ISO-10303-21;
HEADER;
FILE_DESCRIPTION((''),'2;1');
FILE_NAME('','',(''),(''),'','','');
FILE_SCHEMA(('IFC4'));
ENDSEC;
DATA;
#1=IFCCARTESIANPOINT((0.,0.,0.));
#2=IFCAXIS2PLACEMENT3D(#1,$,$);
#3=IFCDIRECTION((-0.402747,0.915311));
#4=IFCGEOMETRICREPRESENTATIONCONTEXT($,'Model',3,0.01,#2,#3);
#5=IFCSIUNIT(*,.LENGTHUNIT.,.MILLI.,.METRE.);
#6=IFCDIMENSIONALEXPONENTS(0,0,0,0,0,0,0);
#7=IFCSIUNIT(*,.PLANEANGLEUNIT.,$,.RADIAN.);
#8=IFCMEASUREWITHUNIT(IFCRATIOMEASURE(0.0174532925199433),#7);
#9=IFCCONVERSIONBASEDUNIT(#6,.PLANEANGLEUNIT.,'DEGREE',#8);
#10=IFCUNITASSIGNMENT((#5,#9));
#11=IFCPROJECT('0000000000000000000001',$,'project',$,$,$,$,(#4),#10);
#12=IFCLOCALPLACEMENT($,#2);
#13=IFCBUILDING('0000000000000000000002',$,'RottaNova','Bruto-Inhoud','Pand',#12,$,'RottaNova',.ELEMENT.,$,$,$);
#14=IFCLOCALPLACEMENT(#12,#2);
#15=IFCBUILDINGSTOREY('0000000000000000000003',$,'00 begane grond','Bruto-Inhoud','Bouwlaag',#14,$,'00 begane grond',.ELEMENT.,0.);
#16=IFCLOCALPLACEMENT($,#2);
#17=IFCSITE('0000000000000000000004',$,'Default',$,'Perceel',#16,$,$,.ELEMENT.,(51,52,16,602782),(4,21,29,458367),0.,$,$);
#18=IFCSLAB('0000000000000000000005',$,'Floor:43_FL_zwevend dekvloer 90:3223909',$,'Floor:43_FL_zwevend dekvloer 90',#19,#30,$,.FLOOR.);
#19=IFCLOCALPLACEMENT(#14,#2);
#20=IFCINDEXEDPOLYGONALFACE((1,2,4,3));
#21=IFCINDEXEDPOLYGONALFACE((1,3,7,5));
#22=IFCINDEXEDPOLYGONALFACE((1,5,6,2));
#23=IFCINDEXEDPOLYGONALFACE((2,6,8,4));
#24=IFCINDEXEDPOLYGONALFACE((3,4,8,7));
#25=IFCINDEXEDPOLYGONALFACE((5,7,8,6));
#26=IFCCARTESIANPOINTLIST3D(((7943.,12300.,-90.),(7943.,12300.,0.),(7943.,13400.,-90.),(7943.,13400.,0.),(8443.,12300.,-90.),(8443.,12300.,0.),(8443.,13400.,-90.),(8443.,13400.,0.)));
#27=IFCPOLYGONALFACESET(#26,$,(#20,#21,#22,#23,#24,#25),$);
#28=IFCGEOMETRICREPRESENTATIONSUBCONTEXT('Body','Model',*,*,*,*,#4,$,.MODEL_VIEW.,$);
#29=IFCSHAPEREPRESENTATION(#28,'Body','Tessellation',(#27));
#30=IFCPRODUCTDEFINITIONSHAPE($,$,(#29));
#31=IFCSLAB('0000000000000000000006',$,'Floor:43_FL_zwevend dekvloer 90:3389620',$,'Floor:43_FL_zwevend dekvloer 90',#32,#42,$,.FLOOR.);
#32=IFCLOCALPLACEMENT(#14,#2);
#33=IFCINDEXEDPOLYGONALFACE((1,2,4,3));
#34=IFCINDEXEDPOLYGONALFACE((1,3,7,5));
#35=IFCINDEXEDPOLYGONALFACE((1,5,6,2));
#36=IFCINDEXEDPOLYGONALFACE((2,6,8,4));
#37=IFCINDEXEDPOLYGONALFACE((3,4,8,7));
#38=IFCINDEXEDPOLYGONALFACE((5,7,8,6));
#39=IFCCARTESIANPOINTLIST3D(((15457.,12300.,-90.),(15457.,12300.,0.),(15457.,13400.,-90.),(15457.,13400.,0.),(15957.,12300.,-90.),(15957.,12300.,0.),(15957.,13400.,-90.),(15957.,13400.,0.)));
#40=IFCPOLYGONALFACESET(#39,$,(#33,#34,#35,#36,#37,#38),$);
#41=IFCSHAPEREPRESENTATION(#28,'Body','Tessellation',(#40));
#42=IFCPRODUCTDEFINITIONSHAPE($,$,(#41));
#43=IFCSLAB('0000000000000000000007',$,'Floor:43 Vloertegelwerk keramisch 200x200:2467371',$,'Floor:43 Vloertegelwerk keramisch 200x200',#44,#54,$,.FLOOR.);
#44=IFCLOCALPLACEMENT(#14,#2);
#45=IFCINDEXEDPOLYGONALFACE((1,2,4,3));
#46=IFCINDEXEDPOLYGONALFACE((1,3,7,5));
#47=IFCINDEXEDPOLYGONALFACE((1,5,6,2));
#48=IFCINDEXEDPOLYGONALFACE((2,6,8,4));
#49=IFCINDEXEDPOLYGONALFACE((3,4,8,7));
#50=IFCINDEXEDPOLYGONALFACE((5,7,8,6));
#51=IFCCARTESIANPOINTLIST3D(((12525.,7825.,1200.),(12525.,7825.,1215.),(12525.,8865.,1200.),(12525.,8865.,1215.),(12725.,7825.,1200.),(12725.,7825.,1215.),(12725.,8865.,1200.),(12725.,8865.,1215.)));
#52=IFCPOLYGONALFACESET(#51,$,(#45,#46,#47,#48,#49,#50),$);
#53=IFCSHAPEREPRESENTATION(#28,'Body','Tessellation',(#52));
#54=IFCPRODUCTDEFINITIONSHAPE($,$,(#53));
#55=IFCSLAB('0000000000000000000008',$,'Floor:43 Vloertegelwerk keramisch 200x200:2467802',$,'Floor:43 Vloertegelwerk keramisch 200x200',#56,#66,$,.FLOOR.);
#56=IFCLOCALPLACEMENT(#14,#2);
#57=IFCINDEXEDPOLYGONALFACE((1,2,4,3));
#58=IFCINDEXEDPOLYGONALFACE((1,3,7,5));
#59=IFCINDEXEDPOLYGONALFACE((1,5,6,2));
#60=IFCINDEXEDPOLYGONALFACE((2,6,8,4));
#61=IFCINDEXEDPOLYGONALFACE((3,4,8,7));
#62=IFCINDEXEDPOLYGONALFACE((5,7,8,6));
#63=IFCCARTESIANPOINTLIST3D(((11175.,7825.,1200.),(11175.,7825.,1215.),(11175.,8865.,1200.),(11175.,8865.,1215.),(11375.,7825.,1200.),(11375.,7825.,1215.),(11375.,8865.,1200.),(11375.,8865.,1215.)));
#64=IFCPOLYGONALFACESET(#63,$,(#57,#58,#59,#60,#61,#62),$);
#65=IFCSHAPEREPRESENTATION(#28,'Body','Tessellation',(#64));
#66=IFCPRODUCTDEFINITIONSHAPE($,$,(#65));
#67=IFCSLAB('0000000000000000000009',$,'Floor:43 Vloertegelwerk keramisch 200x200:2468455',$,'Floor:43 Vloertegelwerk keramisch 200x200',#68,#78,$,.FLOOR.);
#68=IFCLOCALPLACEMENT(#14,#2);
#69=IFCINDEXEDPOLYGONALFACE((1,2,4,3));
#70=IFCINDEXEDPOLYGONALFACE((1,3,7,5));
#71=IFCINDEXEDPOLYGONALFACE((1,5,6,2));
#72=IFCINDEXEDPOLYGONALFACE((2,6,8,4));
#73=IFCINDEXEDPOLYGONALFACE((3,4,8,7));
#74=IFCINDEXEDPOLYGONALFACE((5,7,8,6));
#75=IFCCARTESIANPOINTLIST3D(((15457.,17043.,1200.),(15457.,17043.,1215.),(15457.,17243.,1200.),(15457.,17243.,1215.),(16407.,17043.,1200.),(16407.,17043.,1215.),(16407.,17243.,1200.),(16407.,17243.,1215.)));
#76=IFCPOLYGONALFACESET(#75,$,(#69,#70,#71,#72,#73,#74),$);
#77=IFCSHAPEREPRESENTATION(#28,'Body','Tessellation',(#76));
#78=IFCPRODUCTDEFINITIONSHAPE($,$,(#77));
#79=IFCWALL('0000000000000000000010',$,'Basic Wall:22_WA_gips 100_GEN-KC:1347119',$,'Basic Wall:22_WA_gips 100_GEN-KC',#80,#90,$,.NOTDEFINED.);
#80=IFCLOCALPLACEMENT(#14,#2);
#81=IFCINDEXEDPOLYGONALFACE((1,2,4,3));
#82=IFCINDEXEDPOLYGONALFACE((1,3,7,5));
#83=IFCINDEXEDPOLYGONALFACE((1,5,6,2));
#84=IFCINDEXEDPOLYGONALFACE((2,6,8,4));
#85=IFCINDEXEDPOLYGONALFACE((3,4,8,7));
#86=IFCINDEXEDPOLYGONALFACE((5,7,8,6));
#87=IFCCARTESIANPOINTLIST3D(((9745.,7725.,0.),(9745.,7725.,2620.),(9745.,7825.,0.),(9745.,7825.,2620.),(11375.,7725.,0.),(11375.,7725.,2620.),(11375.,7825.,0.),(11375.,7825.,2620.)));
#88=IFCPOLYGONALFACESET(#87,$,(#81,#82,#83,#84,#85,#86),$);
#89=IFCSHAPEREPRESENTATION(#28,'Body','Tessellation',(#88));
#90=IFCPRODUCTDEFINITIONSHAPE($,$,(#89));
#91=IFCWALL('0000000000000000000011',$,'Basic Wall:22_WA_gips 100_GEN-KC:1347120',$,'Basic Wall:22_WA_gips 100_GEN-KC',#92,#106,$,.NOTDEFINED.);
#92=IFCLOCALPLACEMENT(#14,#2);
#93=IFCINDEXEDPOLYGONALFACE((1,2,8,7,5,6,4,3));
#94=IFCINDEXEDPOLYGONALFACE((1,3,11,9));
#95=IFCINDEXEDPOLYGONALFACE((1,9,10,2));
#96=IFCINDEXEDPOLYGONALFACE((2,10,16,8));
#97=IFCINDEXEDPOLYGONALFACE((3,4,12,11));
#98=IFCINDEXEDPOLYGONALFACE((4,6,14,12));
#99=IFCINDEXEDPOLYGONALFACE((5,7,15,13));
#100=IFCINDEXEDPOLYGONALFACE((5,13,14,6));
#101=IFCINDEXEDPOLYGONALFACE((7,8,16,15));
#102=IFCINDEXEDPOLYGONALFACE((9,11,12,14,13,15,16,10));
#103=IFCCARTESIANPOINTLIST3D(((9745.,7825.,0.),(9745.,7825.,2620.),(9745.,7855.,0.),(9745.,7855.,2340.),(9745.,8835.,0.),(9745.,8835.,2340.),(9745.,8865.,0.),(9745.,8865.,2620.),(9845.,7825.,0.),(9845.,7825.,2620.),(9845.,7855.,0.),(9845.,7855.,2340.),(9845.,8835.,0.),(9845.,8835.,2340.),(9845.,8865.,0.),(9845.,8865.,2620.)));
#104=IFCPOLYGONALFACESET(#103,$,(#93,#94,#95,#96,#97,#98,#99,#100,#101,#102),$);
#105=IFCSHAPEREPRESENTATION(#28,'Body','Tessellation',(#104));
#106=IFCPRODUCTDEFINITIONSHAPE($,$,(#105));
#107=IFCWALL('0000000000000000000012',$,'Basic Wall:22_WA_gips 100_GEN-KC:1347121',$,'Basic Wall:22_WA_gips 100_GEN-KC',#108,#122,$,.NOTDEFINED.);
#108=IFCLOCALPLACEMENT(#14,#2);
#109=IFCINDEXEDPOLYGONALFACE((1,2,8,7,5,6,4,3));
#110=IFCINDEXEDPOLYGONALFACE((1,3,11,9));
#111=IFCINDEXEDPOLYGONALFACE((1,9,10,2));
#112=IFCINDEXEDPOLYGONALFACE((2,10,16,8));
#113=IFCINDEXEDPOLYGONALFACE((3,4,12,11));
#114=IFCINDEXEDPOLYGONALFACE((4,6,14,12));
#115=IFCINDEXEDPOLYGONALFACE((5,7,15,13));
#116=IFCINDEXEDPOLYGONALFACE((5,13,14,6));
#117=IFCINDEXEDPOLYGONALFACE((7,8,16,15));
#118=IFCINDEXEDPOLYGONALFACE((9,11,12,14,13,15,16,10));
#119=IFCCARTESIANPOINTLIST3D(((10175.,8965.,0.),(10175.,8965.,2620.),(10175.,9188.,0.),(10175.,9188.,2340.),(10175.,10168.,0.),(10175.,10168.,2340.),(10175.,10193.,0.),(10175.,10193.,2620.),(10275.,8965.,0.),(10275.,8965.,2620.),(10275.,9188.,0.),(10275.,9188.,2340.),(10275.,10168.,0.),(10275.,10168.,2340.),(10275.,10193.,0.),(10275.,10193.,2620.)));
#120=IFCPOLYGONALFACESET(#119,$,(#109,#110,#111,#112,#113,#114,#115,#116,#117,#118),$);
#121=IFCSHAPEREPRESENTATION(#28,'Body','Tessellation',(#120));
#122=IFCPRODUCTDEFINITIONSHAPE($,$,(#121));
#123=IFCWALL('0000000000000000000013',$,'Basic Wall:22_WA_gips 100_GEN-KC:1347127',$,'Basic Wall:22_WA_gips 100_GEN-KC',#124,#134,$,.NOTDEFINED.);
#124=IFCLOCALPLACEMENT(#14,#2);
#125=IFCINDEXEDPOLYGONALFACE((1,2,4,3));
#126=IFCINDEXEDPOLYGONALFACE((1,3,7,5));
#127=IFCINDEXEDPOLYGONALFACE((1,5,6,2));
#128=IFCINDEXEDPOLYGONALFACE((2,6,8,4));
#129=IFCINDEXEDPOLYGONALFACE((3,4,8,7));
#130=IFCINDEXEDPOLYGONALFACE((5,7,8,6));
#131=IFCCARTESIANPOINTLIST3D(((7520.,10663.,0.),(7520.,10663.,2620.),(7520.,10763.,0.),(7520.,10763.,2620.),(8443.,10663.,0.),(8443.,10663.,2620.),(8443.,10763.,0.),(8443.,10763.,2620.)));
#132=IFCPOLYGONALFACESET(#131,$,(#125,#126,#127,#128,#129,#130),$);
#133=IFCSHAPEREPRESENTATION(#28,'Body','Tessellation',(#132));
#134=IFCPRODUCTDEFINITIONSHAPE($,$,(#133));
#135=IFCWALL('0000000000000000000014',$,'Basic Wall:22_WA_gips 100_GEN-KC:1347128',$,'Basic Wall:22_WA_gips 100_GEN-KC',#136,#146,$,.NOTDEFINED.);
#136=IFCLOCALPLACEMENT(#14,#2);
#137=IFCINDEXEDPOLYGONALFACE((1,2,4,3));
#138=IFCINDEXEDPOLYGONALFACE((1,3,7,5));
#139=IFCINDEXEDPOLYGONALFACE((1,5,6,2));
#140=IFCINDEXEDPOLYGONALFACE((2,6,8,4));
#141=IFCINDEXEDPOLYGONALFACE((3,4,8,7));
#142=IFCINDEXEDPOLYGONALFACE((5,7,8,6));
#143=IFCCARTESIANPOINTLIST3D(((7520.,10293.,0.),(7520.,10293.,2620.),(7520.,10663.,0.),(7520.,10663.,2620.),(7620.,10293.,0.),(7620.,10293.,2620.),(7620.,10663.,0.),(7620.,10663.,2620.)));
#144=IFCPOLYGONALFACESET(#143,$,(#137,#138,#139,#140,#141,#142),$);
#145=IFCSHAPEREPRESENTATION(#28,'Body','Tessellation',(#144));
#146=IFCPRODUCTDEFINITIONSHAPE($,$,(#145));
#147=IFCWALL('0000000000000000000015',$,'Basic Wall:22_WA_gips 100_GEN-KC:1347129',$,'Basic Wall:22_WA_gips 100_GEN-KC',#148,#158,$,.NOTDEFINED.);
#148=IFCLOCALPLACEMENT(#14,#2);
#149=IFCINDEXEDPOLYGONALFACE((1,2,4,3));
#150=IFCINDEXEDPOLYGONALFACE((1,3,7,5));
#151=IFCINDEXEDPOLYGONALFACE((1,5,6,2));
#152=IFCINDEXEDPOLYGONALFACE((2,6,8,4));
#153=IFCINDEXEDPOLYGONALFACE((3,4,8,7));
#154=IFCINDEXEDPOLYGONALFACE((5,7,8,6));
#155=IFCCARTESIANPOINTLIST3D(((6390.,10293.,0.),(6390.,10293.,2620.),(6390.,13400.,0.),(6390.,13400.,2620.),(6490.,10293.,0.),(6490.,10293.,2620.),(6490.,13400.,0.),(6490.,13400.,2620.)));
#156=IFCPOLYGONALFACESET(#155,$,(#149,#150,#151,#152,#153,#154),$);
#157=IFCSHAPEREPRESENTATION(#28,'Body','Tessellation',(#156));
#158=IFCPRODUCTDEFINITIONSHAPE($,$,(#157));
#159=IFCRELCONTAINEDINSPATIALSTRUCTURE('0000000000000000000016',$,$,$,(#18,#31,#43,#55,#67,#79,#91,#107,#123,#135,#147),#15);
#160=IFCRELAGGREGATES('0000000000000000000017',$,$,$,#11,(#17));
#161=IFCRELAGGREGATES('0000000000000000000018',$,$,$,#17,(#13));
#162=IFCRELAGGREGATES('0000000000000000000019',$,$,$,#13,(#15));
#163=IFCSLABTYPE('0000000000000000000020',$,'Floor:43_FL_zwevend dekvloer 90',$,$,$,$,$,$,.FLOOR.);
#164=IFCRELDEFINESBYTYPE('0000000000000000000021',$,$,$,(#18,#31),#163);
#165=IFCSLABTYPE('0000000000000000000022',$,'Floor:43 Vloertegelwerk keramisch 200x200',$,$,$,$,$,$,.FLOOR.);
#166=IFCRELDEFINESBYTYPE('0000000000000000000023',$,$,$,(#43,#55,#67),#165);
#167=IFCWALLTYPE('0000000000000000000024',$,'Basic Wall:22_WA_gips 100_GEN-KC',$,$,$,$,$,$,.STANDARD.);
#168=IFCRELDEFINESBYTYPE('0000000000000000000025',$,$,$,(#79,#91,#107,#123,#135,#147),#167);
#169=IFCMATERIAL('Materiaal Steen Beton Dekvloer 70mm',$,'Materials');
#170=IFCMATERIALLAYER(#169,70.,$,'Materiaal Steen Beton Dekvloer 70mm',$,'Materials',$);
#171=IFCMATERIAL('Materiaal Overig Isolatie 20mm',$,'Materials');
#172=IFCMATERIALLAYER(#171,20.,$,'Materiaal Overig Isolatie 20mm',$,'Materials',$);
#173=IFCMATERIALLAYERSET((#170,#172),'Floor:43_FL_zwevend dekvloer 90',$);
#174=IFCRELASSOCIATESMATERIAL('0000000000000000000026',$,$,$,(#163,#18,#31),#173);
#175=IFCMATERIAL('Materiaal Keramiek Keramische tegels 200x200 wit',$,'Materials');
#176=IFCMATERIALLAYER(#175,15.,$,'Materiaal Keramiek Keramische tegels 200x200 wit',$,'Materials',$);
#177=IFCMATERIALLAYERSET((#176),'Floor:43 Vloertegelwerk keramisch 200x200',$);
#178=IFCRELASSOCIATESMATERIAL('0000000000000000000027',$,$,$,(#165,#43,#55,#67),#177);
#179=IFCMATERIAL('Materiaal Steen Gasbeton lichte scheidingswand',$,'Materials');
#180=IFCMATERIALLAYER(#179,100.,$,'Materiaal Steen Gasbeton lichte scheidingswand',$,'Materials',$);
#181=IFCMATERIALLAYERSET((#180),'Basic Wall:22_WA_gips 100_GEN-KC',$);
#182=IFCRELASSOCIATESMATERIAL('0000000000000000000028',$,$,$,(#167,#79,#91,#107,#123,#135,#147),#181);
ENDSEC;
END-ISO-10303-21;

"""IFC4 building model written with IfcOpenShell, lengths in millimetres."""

from ifc_helpers import new_model, entity, si_unit, converted_unit, direction, frame, frame_2d, origin, origin_2d_with_axis, place, context, subcontext, project, spatial, rectangle, extrude, material, layer, layer_set, layer_usage, type_object, element, save


model = new_model("IFC4")

# Units and contexts
model_context = context("Model", 3, precision=0.01, world=origin(), true_north=direction((-0.402747, 0.915311)))
body_context = subcontext(model_context, "Body", "Model", "MODEL_VIEW")
ifc_project = project(units=[si_unit("LENGTHUNIT", "METRE", prefix="MILLI"), converted_unit("PLANEANGLEUNIT", "DEGREE", entity("IfcRatioMeasure", 0.0174532925199433), si_unit("PLANEANGLEUNIT", "RADIAN"), dimensions=[0, 0, 0, 0, 0, 0, 0])], contexts=[model_context])

# Site, building, storey
site_placement = place(None, origin())
site = spatial("IfcSite", under=ifc_project, at=site_placement, Name="Default", ObjectType="Perceel", CompositionType="ELEMENT", RefLatitude=(51, 52, 16, 602782), RefLongitude=(4, 21, 29, 458367), RefElevation=0.0)
building_placement = place(None, origin())
building = spatial("IfcBuilding", under=site, at=building_placement, Name="RottaNova", Description="Bruto-Inhoud", ObjectType="Pand", LongName="RottaNova", CompositionType="ELEMENT")
storey_placement = place(building_placement, origin())
storey = spatial("IfcBuildingStorey", under=building, at=storey_placement, Name="00 begane grond", Description="Bruto-Inhoud", ObjectType="Bouwlaag", LongName="00 begane grond", CompositionType="ELEMENT", Elevation=0.0)

# Slabs
ifc_material_1 = material(Name="Materiaal Steen Beton Dekvloer 70mm", Category="Materials")
ifc_layer_1 = layer(ifc_material_1, 70.0, Name="Materiaal Steen Beton Dekvloer 70mm", Category="Materials")
ifc_material_2 = material(Name="Materiaal Overig Isolatie 20mm", Category="Materials")
ifc_layer_2 = layer(ifc_material_2, 20.0, Name="Materiaal Overig Isolatie 20mm", Category="Materials")
ifc_layer_set_1 = layer_set([ifc_layer_1, ifc_layer_2], Name="Floor:43_FL_zwevend dekvloer 90")
ifc_layer_usage_1 = layer_usage(ifc_layer_set_1, "AXIS3", "POSITIVE", 0.0)
slab_type_1 = type_object("IfcSlabType", Name="Floor:43_FL_zwevend dekvloer 90", PredefinedType="FLOOR", material=ifc_layer_set_1)
slab_1_placement = place(storey_placement, origin())
element("IfcSlab", 1, at=slab_1_placement, inside=storey, type_object=slab_type_1, material=ifc_layer_usage_1, Name="Floor:43_FL_zwevend dekvloer 90:3223909", ObjectType="Floor:43_FL_zwevend dekvloer 90", PredefinedType="FLOOR", context=body_context, shape_type="SweptSolid", body=[
    extrude(rectangle(XDim=1100.0, YDim=500.0, at=frame_2d((0.0, 0.0), x_axis=(1.0, 0.0))), frame((8193.0, 12850.0, 0.0), z_axis=(0.0, 0.0, -1.0), x_axis=(0.0, 1.0, 0.0)), (0.0, 0.0, 1.0), 90.0),
])
slab_2_placement = place(storey_placement, origin())
element("IfcSlab", 2, at=slab_2_placement, inside=storey, type_object=slab_type_1, material=ifc_layer_usage_1, Name="Floor:43_FL_zwevend dekvloer 90:3389620", ObjectType="Floor:43_FL_zwevend dekvloer 90", PredefinedType="FLOOR", context=body_context, shape_type="SweptSolid", body=[
    extrude(rectangle(XDim=1100.0, YDim=500.0, at=frame_2d((0.0, 0.0), x_axis=(1.0, 0.0))), frame((15707.0, 12850.0, 0.0), z_axis=(0.0, 0.0, -1.0), x_axis=(0.0, 1.0, 0.0)), (0.0, 0.0, 1.0), 90.0),
])
ifc_material_3 = material(Name="Materiaal Keramiek Keramische tegels 200x200 wit", Category="Materials")
ifc_layer_3 = layer(ifc_material_3, 15.0, Name="Materiaal Keramiek Keramische tegels 200x200 wit", Category="Materials")
ifc_layer_set_2 = layer_set([ifc_layer_3], Name="Floor:43 Vloertegelwerk keramisch 200x200")
ifc_layer_usage_2 = layer_usage(ifc_layer_set_2, "AXIS3", "POSITIVE", 0.0)
slab_type_2 = type_object("IfcSlabType", Name="Floor:43 Vloertegelwerk keramisch 200x200", PredefinedType="FLOOR", material=ifc_layer_set_2)
slab_3_placement = place(storey_placement, origin())
element("IfcSlab", 3, at=slab_3_placement, inside=storey, type_object=slab_type_2, material=ifc_layer_usage_2, Name="Floor:43 Vloertegelwerk keramisch 200x200:2467371", ObjectType="Floor:43 Vloertegelwerk keramisch 200x200", PredefinedType="FLOOR", context=body_context, shape_type="SweptSolid", body=[
    extrude(rectangle(XDim=1040.0, YDim=200.0, at=origin_2d_with_axis()), frame((12625.0, 8345.0, 1215.0), z_axis=(0.0, 0.0, -1.0), x_axis=(0.0, 1.0, 0.0)), (0.0, 0.0, 1.0), 15.0),
])
slab_4_placement = place(storey_placement, origin())
element("IfcSlab", 4, at=slab_4_placement, inside=storey, type_object=slab_type_2, material=ifc_layer_usage_2, Name="Floor:43 Vloertegelwerk keramisch 200x200:2467802", ObjectType="Floor:43 Vloertegelwerk keramisch 200x200", PredefinedType="FLOOR", context=body_context, shape_type="SweptSolid", body=[
    extrude(rectangle(XDim=1040.0, YDim=200.0, at=origin_2d_with_axis()), frame((11275.0, 8345.0, 1215.0), z_axis=(0.0, 0.0, -1.0), x_axis=(0.0, 1.0, 0.0)), (0.0, 0.0, 1.0), 15.0),
])
slab_5_placement = place(storey_placement, origin())
element("IfcSlab", 5, at=slab_5_placement, inside=storey, type_object=slab_type_2, material=ifc_layer_usage_2, Name="Floor:43 Vloertegelwerk keramisch 200x200:2468455", ObjectType="Floor:43 Vloertegelwerk keramisch 200x200", PredefinedType="FLOOR", context=body_context, shape_type="SweptSolid", body=[
    extrude(rectangle(XDim=200.0, YDim=950.0, at=frame_2d((0.0, 0.0), x_axis=(1.0, 0.0))), frame((15932.0, 17143.0, 1215.0), z_axis=(0.0, 0.0, -1.0), x_axis=(0.0, 1.0, 0.0)), (0.0, 0.0, 1.0), 15.0),
])

# Wall
ifc_material_4 = material(Name="Materiaal Steen Gasbeton lichte scheidingswand", Category="Materials")
ifc_layer_4 = layer(ifc_material_4, 100.0, Name="Materiaal Steen Gasbeton lichte scheidingswand", Category="Materials")
ifc_layer_set_3 = layer_set([ifc_layer_4], Name="Basic Wall:22_WA_gips 100_GEN-KC")
wall_type_1 = type_object("IfcWallType", Name="Basic Wall:22_WA_gips 100_GEN-KC", PredefinedType="STANDARD", material=ifc_layer_set_3)
wall_1_placement = place(storey_placement, frame((9745.0, 7775.0, 0.0)))
element("IfcWall", 6, at=wall_1_placement, inside=storey, type_object=wall_type_1, material=ifc_layer_set_3, Name="Basic Wall:22_WA_gips 100_GEN-KC:1347119", ObjectType="Basic Wall:22_WA_gips 100_GEN-KC", PredefinedType="NOTDEFINED", context=body_context, shape_type="SweptSolid", body=[
    extrude(rectangle(XDim=1630.0, YDim=100.0, at=frame_2d((815.0, 0.0), x_axis=(-1.0, 0.0))), origin(), (0.0, 0.0, 1.0), 2620.0),
])

# Walls, openings
wall_2_placement = place(storey_placement, frame((9795.0, 8865.0, 0.0), z_axis=(0.0, 0.0, 1.0), x_axis=(0.0, -1.0, 0.0)))
wall_2 = element("IfcWall", 7, at=wall_2_placement, inside=storey, type_object=wall_type_1, material=ifc_layer_set_3, Name="Basic Wall:22_WA_gips 100_GEN-KC:1347120", ObjectType="Basic Wall:22_WA_gips 100_GEN-KC", PredefinedType="NOTDEFINED", context=body_context, shape_type="SweptSolid", body=[
    extrude(rectangle(XDim=1040.0, YDim=100.0, at=frame_2d((520.0, 0.0), x_axis=(1.0, 0.0))), origin(), (0.0, 0.0, 1.0), 2620.0),
])
opening_1_placement = place(wall_2_placement, frame((1010.0, 50.0, -90.0)))
element("IfcOpeningElement", 8, at=opening_1_placement, cuts=wall_2, PredefinedType="OPENING", context=body_context, shape_type="SweptSolid", body=[
    extrude(rectangle(XDim=2430.0, YDim=980.0, at=frame_2d((1215.0, 490.0), x_axis=(1.0, 0.0))), frame((0.0, 0.0, 0.0), z_axis=(0.0, -1.0, 0.0), x_axis=(0.0, 0.0, 1.0)), (0.0, 0.0, 1.0), 100.0),
])
wall_3_placement = place(storey_placement, frame((10225.0, 8965.0, 0.0), z_axis=(0.0, 0.0, 1.0), x_axis=(0.0, 1.0, 0.0)))
wall_3 = element("IfcWall", 9, at=wall_3_placement, inside=storey, type_object=wall_type_1, material=ifc_layer_set_3, Name="Basic Wall:22_WA_gips 100_GEN-KC:1347121", ObjectType="Basic Wall:22_WA_gips 100_GEN-KC", PredefinedType="NOTDEFINED", context=body_context, shape_type="SweptSolid", body=[
    extrude(rectangle(XDim=1228.0, YDim=100.0, at=frame_2d((614.0, 0.0), x_axis=(1.0, 0.0))), origin(), (0.0, 0.0, 1.0), 2620.0),
])
opening_2_placement = place(wall_3_placement, frame((223.0, -50.0, -90.0)))
element("IfcOpeningElement", 10, at=opening_2_placement, cuts=wall_3, PredefinedType="OPENING", context=body_context, shape_type="SweptSolid", body=[
    extrude(rectangle(XDim=2430.0, YDim=980.0, at=frame_2d((1215.0, 490.0), x_axis=(1.0, 0.0))), frame((0.0, 0.0, 0.0), z_axis=(0.0, 1.0, 0.0), x_axis=(0.0, 0.0, 1.0)), (0.0, 0.0, 1.0), 100.0),
])

# Walls
wall_4_placement = place(storey_placement, frame((7520.0, 10713.0, 0.0)))
element("IfcWall", 11, at=wall_4_placement, inside=storey, type_object=wall_type_1, material=ifc_layer_set_3, Name="Basic Wall:22_WA_gips 100_GEN-KC:1347127", ObjectType="Basic Wall:22_WA_gips 100_GEN-KC", PredefinedType="NOTDEFINED", context=body_context, shape_type="SweptSolid", body=[
    extrude(rectangle(XDim=923.0, YDim=100.0, at=frame_2d((461.5, 0.0), x_axis=(-1.0, 0.0))), origin(), (0.0, 0.0, 1.0), 2620.0),
])
wall_5_placement = place(storey_placement, frame((7570.0, 10663.0, 0.0), z_axis=(0.0, 0.0, 1.0), x_axis=(0.0, -1.0, 0.0)))
element("IfcWall", 12, at=wall_5_placement, inside=storey, type_object=wall_type_1, material=ifc_layer_set_3, Name="Basic Wall:22_WA_gips 100_GEN-KC:1347128", ObjectType="Basic Wall:22_WA_gips 100_GEN-KC", PredefinedType="NOTDEFINED", context=body_context, shape_type="SweptSolid", body=[
    extrude(rectangle(XDim=370.0, YDim=100.0, at=frame_2d((185.0, 0.0), x_axis=(-1.0, 0.0))), origin(), (0.0, 0.0, 1.0), 2620.0),
])
wall_6_placement = place(storey_placement, frame((6440.0, 13400.0, 0.0), z_axis=(0.0, 0.0, 1.0), x_axis=(0.0, -1.0, 0.0)))
element("IfcWall", 13, at=wall_6_placement, inside=storey, type_object=wall_type_1, material=ifc_layer_set_3, Name="Basic Wall:22_WA_gips 100_GEN-KC:1347129", ObjectType="Basic Wall:22_WA_gips 100_GEN-KC", PredefinedType="NOTDEFINED", context=body_context, shape_type="SweptSolid", body=[
    extrude(rectangle(XDim=3107.0, YDim=100.0, at=frame_2d((1553.5, 0.0), x_axis=(-1.0, 0.0))), origin(), (0.0, 0.0, 1.0), 2620.0),
])

save(model, "model.ifc")
